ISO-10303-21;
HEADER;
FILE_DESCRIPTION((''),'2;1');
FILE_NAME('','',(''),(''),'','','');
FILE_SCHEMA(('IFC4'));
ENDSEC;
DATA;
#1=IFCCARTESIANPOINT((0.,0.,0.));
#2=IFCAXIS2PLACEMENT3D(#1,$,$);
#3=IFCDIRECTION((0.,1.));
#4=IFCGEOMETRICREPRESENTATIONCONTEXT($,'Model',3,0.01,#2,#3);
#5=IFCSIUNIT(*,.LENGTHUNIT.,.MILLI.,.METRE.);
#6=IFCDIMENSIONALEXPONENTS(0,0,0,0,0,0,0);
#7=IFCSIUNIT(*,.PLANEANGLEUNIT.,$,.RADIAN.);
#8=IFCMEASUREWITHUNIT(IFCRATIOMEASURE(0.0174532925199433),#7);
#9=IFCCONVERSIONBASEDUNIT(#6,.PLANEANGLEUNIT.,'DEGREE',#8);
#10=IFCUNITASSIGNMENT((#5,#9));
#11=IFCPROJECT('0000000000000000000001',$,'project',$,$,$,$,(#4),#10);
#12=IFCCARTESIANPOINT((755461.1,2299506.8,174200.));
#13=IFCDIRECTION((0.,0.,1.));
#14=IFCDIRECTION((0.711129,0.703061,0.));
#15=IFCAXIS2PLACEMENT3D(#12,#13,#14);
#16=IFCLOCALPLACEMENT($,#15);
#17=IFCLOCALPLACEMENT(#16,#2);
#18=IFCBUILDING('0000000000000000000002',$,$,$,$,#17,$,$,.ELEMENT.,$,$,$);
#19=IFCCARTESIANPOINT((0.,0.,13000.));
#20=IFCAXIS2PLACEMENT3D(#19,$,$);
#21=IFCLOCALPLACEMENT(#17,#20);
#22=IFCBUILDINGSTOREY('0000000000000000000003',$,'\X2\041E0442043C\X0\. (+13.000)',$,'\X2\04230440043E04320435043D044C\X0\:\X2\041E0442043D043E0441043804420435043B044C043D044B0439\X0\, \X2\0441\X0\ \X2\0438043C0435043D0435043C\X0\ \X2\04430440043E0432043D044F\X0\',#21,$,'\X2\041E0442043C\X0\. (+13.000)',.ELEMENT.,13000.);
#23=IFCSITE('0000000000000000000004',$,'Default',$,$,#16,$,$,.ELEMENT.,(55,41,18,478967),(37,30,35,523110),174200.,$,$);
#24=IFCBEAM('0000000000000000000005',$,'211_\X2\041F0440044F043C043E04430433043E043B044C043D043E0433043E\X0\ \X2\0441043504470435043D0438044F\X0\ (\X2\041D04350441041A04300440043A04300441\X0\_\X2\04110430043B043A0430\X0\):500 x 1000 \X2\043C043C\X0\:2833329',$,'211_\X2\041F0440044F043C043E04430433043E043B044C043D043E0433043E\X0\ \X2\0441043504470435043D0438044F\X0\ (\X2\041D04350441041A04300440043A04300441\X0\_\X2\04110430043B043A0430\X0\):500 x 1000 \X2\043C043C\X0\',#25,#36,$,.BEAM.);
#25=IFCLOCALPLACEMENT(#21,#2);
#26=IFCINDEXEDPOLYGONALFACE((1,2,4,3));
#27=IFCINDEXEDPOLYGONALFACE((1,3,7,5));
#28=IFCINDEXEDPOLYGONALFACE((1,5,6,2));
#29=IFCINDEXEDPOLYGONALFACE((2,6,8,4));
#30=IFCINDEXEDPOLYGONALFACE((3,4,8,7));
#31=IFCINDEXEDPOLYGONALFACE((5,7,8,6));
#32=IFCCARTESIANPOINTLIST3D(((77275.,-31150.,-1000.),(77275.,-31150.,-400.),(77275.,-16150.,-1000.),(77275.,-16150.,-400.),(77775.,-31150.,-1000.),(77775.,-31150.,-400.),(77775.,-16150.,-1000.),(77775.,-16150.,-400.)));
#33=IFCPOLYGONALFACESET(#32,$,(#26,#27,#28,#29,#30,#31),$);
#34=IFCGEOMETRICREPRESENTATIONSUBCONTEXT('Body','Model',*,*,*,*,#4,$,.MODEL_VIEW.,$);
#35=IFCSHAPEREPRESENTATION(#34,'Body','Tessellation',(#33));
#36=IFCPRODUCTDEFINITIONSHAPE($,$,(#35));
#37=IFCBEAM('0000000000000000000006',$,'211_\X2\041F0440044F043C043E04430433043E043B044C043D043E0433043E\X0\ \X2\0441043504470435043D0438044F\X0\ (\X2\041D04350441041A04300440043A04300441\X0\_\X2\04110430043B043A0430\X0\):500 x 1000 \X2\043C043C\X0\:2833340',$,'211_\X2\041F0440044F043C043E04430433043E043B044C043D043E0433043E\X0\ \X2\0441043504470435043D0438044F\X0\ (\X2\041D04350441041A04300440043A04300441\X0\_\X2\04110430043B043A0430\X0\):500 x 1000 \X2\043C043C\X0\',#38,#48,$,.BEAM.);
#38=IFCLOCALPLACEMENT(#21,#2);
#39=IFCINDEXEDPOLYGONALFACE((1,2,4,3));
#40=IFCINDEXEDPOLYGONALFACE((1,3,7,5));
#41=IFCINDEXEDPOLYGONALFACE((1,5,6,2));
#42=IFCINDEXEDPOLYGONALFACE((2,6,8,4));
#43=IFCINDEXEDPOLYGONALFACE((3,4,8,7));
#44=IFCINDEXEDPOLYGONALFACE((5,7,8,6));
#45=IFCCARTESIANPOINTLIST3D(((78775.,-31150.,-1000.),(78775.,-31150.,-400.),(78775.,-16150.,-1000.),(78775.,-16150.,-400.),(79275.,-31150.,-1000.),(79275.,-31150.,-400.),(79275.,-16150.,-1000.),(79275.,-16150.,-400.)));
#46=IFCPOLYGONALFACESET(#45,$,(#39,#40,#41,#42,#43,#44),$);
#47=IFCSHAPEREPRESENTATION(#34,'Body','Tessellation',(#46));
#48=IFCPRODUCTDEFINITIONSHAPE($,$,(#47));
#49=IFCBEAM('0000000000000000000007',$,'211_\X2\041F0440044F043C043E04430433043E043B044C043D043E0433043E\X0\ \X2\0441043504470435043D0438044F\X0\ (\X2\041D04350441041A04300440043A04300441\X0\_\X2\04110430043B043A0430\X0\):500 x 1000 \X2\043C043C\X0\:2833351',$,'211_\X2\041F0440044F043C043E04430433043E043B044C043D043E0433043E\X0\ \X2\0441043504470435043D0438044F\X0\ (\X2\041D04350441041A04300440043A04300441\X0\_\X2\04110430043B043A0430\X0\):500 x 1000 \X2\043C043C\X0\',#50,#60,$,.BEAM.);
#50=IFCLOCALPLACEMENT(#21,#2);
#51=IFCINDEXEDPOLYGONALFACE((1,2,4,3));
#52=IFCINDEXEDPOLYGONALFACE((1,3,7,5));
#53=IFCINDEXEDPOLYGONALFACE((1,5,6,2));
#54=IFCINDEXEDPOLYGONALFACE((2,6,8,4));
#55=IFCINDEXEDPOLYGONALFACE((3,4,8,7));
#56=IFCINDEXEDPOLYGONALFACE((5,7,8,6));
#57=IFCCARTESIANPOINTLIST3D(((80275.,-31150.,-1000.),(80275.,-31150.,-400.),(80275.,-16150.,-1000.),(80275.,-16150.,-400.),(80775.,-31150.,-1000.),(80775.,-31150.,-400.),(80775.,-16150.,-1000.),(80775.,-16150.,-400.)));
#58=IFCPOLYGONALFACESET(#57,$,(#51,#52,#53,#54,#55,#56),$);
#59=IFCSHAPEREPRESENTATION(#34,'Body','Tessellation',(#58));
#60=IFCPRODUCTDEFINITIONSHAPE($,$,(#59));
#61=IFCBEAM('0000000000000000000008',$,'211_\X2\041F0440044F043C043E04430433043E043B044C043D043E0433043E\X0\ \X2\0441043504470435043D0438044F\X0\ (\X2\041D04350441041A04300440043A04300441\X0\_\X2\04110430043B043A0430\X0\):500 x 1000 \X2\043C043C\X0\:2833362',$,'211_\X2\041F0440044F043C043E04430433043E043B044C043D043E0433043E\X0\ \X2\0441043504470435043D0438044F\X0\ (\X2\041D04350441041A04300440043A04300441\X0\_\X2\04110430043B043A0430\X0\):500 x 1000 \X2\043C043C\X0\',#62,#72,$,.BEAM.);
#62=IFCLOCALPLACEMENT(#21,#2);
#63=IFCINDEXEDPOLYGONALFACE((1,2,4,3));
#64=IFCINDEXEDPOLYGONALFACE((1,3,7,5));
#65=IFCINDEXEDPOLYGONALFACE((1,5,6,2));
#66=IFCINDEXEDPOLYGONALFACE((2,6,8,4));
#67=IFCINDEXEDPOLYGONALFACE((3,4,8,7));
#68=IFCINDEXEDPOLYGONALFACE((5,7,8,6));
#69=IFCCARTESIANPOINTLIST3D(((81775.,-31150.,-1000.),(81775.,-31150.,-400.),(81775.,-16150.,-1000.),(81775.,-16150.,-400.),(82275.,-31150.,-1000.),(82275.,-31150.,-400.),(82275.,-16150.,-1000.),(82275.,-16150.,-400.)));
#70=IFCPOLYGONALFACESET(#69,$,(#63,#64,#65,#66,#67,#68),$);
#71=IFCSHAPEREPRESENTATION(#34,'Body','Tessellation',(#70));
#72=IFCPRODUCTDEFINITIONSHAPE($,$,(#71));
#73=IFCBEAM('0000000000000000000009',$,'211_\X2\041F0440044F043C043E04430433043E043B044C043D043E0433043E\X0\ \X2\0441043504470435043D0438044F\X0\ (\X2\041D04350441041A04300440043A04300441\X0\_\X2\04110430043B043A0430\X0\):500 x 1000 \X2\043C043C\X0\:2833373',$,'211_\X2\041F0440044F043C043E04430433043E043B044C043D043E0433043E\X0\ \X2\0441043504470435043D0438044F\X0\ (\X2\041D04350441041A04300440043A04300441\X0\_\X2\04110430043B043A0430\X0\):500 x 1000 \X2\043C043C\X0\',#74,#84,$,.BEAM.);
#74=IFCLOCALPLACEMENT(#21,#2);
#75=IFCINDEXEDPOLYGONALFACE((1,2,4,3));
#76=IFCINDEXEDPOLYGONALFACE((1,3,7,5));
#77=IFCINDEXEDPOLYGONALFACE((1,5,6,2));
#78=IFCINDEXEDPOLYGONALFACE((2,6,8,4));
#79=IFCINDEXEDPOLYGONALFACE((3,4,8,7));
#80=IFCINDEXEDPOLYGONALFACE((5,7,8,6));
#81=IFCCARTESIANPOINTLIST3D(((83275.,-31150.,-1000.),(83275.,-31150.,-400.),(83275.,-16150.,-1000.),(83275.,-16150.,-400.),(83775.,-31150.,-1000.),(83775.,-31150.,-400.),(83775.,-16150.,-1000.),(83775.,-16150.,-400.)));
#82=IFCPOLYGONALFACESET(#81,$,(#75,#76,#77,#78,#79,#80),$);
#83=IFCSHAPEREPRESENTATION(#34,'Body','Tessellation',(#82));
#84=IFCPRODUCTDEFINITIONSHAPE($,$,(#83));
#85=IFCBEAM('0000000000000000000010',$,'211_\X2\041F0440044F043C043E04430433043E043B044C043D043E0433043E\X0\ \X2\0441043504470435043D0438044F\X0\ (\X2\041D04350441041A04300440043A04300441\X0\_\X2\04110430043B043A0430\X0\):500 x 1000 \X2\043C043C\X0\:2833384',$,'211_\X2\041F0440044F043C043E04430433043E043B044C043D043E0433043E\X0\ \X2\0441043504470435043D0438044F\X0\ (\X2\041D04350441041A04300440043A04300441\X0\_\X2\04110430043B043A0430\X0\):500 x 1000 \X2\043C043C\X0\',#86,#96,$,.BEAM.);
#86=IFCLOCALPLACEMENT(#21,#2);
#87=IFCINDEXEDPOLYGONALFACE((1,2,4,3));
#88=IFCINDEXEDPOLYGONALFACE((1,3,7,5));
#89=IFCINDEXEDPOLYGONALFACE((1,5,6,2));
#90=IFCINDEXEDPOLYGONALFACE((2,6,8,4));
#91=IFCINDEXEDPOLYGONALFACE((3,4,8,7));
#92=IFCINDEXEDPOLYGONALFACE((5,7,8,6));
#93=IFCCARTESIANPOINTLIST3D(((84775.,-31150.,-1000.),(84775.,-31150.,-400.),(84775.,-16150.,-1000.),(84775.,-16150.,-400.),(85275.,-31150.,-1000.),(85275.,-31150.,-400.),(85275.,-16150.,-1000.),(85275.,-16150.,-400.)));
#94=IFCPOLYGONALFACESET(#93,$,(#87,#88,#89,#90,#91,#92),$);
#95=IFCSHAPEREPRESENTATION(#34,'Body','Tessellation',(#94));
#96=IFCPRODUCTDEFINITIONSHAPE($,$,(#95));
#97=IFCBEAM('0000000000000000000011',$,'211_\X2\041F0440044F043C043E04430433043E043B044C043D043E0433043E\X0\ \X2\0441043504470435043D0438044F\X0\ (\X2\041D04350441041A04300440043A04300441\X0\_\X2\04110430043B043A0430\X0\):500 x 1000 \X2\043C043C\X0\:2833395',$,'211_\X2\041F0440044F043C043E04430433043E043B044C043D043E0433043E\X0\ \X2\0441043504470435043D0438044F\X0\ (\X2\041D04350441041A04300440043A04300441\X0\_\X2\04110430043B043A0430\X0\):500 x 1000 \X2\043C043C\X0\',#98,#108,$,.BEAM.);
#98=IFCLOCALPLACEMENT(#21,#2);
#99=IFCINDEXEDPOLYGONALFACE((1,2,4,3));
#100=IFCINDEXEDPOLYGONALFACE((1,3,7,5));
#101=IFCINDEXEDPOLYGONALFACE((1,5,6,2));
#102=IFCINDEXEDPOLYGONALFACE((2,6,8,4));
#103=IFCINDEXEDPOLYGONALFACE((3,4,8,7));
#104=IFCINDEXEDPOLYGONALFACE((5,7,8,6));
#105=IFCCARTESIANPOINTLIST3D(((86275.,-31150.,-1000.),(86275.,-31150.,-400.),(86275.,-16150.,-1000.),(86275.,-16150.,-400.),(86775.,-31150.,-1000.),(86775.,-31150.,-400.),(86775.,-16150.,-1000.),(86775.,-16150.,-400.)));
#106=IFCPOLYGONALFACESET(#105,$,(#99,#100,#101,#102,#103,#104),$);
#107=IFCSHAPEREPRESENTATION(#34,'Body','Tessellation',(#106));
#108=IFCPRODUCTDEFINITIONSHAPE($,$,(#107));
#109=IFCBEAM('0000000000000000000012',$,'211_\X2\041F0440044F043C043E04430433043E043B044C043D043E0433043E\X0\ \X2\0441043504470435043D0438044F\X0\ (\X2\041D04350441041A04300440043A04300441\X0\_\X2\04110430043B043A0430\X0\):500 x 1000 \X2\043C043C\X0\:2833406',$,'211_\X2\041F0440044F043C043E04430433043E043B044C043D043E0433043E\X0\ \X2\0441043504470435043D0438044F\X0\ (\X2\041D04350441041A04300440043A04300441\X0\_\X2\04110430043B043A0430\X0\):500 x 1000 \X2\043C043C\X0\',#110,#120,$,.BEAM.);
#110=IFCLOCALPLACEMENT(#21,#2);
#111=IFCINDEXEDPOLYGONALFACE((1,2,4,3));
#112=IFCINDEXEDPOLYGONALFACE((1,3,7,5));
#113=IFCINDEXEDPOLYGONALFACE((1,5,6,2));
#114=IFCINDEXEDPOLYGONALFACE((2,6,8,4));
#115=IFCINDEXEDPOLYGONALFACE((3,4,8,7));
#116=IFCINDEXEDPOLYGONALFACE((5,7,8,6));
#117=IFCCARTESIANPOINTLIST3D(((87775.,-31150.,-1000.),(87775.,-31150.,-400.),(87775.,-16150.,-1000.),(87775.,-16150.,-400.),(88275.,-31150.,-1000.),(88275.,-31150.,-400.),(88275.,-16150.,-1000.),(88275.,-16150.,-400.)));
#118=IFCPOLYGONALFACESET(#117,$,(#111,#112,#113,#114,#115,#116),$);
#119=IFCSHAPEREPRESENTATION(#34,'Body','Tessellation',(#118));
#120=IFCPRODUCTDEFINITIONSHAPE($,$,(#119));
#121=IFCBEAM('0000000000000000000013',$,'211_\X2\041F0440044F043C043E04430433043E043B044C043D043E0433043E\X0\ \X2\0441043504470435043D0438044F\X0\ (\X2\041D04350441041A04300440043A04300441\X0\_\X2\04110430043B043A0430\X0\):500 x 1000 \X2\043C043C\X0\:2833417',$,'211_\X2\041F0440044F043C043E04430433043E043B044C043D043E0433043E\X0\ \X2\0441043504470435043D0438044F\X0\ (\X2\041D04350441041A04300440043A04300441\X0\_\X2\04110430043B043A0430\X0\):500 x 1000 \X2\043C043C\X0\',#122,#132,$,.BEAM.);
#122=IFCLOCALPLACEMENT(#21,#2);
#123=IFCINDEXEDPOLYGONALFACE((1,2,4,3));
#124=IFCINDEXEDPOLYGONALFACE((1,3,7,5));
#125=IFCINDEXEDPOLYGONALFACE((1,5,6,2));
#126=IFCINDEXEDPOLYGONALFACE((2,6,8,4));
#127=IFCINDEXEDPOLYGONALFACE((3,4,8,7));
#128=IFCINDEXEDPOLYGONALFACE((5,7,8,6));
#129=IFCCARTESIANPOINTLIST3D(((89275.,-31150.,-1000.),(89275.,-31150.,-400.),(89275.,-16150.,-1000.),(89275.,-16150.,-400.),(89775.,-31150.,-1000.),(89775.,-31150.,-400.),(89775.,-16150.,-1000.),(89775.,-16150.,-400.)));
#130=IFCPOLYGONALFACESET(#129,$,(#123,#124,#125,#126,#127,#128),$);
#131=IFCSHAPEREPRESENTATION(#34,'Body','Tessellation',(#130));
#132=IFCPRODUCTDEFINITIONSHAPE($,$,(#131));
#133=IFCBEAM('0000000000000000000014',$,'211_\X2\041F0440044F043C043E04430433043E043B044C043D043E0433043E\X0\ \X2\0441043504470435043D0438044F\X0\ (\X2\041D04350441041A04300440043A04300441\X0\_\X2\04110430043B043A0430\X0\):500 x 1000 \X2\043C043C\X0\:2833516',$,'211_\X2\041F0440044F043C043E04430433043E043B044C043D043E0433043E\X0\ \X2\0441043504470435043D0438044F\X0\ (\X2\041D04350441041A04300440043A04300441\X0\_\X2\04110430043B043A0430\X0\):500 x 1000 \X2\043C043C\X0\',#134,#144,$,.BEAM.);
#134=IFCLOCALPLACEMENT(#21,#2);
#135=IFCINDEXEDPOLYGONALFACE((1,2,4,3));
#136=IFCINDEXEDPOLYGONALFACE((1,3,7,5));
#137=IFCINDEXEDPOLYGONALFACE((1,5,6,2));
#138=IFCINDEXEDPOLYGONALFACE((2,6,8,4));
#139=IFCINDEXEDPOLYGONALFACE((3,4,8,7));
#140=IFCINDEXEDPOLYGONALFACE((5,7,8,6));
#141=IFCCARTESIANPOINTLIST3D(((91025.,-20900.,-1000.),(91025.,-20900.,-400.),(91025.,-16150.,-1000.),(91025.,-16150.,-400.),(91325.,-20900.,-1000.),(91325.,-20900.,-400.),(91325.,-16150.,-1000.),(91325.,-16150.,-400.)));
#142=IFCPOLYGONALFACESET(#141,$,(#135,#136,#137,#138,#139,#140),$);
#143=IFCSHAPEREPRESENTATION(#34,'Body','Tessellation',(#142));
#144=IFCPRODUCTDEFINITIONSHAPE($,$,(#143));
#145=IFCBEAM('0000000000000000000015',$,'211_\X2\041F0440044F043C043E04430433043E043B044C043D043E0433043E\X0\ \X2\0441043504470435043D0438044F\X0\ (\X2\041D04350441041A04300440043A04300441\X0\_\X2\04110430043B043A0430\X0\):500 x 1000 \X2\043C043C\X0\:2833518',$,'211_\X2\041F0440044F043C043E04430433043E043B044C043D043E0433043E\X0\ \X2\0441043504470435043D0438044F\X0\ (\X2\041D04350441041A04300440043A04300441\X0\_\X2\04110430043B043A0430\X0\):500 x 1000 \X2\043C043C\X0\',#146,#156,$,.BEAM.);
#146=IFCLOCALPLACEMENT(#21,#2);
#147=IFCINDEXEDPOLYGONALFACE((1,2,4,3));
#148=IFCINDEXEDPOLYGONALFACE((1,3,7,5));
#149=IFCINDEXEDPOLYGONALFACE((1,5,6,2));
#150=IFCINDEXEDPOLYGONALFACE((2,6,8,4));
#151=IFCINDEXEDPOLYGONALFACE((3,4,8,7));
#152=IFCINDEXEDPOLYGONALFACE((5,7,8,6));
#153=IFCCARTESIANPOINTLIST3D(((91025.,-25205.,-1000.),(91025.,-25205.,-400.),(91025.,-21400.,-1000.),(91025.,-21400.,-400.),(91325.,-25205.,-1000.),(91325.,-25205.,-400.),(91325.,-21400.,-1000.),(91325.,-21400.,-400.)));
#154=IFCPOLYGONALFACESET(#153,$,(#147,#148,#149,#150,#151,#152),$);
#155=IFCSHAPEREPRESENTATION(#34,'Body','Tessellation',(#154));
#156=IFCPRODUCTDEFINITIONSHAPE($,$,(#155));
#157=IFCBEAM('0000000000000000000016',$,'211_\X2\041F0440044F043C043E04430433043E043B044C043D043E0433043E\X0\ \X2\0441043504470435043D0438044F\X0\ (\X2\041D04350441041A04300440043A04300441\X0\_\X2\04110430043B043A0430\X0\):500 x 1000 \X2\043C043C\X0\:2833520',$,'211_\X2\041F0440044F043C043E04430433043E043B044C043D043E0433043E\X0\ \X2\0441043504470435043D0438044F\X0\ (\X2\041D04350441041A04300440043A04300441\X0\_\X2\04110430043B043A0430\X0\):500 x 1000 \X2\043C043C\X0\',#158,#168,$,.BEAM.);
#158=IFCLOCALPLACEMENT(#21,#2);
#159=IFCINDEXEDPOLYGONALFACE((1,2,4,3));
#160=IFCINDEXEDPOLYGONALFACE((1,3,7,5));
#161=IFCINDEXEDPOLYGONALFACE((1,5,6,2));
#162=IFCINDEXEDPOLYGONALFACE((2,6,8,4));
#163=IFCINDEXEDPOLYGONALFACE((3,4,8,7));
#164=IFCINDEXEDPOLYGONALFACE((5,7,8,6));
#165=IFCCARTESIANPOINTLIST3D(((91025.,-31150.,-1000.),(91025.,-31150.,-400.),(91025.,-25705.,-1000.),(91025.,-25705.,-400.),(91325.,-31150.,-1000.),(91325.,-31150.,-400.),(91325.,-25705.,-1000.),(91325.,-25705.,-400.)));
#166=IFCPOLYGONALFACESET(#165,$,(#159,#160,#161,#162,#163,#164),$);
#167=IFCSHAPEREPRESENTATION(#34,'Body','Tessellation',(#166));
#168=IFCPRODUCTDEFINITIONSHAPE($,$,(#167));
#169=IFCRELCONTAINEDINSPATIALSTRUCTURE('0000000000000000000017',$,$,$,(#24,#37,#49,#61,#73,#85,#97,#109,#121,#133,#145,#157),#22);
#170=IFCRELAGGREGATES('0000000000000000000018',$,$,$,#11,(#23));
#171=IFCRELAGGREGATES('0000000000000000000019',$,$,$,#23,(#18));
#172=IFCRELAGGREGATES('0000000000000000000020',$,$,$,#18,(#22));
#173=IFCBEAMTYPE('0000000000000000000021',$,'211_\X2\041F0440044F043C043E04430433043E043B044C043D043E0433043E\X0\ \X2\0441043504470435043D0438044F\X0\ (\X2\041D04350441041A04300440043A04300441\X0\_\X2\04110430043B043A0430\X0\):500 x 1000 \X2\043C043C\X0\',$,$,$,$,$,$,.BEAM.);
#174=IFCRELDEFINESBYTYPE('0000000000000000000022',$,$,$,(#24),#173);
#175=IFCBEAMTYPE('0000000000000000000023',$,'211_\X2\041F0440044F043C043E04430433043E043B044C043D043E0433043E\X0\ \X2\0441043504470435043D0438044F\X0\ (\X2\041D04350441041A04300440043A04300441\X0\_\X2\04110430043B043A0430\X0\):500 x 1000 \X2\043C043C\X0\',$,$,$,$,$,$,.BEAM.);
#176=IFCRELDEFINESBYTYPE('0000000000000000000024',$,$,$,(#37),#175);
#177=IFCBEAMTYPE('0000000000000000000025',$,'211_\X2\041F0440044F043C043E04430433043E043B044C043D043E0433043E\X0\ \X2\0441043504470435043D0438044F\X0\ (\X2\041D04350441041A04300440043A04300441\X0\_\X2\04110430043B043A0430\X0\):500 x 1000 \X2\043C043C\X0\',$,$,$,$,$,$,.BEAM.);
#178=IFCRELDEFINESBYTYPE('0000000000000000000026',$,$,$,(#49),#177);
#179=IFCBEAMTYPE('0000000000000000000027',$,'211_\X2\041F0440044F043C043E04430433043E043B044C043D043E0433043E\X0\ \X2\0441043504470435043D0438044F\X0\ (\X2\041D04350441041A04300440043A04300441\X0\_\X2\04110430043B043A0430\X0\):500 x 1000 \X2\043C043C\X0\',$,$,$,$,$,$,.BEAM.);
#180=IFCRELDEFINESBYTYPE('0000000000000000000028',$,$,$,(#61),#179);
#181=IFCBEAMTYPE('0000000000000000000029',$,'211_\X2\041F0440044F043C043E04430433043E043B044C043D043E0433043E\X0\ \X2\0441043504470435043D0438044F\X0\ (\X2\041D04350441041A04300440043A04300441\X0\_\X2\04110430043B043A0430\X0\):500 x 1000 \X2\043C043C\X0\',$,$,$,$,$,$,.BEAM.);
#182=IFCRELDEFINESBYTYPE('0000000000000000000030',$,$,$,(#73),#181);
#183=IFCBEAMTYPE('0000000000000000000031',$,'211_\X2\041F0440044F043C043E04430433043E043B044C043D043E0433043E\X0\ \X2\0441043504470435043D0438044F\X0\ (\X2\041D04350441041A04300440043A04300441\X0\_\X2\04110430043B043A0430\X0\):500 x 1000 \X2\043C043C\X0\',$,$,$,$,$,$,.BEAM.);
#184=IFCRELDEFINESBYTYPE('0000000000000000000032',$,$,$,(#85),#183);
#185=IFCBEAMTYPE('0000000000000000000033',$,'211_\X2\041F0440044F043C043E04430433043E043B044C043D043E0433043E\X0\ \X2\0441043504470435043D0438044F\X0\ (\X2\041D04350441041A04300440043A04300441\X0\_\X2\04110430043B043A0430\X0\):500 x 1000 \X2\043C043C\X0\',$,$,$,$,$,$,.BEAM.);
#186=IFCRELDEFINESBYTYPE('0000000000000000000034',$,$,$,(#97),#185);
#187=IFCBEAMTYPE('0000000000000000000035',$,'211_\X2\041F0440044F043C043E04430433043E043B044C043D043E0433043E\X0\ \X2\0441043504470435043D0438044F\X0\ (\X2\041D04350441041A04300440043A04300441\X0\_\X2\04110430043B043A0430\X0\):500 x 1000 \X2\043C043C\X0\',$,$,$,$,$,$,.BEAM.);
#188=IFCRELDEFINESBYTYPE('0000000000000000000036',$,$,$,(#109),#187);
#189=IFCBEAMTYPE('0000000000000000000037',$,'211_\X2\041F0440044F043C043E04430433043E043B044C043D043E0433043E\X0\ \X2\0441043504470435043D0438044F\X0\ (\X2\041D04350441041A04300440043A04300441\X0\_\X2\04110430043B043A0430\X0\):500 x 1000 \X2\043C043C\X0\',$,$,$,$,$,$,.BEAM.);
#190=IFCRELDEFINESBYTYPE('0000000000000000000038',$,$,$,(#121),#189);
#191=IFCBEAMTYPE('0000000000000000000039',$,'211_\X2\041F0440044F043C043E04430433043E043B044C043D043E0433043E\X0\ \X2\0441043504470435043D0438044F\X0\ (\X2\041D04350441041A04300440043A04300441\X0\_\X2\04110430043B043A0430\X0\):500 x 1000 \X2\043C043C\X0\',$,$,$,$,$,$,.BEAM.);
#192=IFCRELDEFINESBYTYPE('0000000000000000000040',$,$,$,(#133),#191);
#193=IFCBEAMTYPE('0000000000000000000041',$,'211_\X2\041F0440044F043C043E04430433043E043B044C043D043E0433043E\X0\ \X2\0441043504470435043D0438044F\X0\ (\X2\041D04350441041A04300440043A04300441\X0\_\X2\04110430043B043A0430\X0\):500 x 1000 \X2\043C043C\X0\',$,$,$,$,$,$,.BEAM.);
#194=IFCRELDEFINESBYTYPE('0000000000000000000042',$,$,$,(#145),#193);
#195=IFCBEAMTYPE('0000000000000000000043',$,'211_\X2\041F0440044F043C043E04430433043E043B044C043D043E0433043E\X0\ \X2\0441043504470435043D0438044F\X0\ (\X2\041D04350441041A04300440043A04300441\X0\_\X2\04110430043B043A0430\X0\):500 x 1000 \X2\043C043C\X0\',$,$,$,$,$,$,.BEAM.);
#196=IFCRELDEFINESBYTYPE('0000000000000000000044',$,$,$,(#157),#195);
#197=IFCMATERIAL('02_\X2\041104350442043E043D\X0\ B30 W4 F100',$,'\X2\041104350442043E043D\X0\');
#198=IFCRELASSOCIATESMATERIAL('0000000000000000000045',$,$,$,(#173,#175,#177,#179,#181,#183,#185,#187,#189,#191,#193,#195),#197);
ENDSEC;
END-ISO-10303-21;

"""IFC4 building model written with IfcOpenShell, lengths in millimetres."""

from ifc_helpers import new_model, entity, si_unit, converted_unit, direction, frame, origin, place, context, subcontext, project, spatial, indexed_curve, outline, extrude, source, transform, mapped, material, type_object, type_shapes, element, save


model = new_model("IFC4")

# Units and contexts
model_context = context("Model", 3, precision=0.01, world=origin(), true_north=direction((0.0, 1.0)))
body_context = subcontext(model_context, "Body", "Model", "MODEL_VIEW")
ifc_project = project(units=[si_unit("LENGTHUNIT", "METRE", prefix="MILLI"), converted_unit("PLANEANGLEUNIT", "DEGREE", entity("IfcRatioMeasure", 0.0174532925199433), si_unit("PLANEANGLEUNIT", "RADIAN"), dimensions=[0, 0, 0, 0, 0, 0, 0])], contexts=[model_context])

# Site, building, storey
site_placement = place(None, frame((755461.1, 2299506.8, 174200.0), z_axis=(0.0, 0.0, 1.0), x_axis=(0.711129, 0.703061, 0.0)))
site = spatial("IfcSite", under=ifc_project, at=site_placement, Name="Default", CompositionType="ELEMENT", RefLatitude=(55, 41, 18, 478967), RefLongitude=(37, 30, 35, 523110), RefElevation=174200.0)
building_placement = place(site_placement, origin())
building = spatial("IfcBuilding", under=site, at=building_placement, CompositionType="ELEMENT")
storey_placement = place(building_placement, frame((0.0, 0.0, 13000.0)))
storey = spatial("IfcBuildingStorey", under=building, at=storey_placement, Name="Отм. (+13.000)", ObjectType="Уровень:Относительный, с именем уровня", LongName="Отм. (+13.000)", CompositionType="ELEMENT", Elevation=13000.0)

# Beams
ifc_material_1 = material(Name="02_Бетон B30 W4 F100", Category="Бетон")
beam_type_1 = type_object("IfcBeamType", Name="211_Прямоугольного сечения (НесКаркас_Балка):500 x 1000 мм", PredefinedType="BEAM", material=ifc_material_1)
shared_shape_1 = source(origin(), body_context, "Body", "SweptSolid", [
    extrude(outline(indexed_curve([(-250.0, -300.0), (250.0, -300.0), (250.0, 300.0), (-250.0, 300.0), (-250.0, -300.0)], self_intersect=False)), frame((77525.0, -16150.0, 12300.0), z_axis=(0.0, -1.0, 0.0), x_axis=(-1.0, 0.0, 0.0)), (0.0, 0.0, 1.0), 15000.0),
])
type_shapes(beam_type_1, [shared_shape_1])
beam_1_placement = place(storey_placement, frame((0.0, 0.0, -13000.0)))
element("IfcBeam", 1, at=beam_1_placement, inside=storey, type_object=beam_type_1, Name="211_Прямоугольного сечения (НесКаркас_Балка):500 x 1000 мм:2833329", ObjectType="211_Прямоугольного сечения (НесКаркас_Балка):500 x 1000 мм", PredefinedType="BEAM", context=body_context, shape_type="MappedRepresentation", body=[
    mapped(shared_shape_1, transform((0.0, 0.0, 0.0), scale=1.0)),
])
beam_type_2 = type_object("IfcBeamType", Name="211_Прямоугольного сечения (НесКаркас_Балка):500 x 1000 мм", PredefinedType="BEAM", material=ifc_material_1)
shared_shape_2 = source(origin(), body_context, "Body", "SweptSolid", [
    extrude(outline(indexed_curve([(-250.0, -300.0), (250.0, -300.0), (250.0, 300.0), (-250.0, 300.0), (-250.0, -300.0)], self_intersect=False)), frame((79025.0, -16150.0, 12300.0), z_axis=(0.0, -1.0, 0.0), x_axis=(-1.0, 0.0, 0.0)), (0.0, 0.0, 1.0), 15000.0),
])
type_shapes(beam_type_2, [shared_shape_2])
beam_2_placement = place(storey_placement, frame((0.0, 0.0, -13000.0)))
element("IfcBeam", 2, at=beam_2_placement, inside=storey, type_object=beam_type_2, Name="211_Прямоугольного сечения (НесКаркас_Балка):500 x 1000 мм:2833340", ObjectType="211_Прямоугольного сечения (НесКаркас_Балка):500 x 1000 мм", PredefinedType="BEAM", context=body_context, shape_type="MappedRepresentation", body=[
    mapped(shared_shape_2, transform((0.0, 0.0, 0.0), scale=1.0)),
])
beam_type_3 = type_object("IfcBeamType", Name="211_Прямоугольного сечения (НесКаркас_Балка):500 x 1000 мм", PredefinedType="BEAM", material=ifc_material_1)
shared_shape_3 = source(origin(), body_context, "Body", "SweptSolid", [
    extrude(outline(indexed_curve([(-250.0, -300.0), (250.0, -300.0), (250.0, 300.0), (-250.0, 300.0), (-250.0, -300.0)], self_intersect=False)), frame((80525.0, -16150.0, 12300.0), z_axis=(0.0, -1.0, 0.0), x_axis=(-1.0, 0.0, 0.0)), (0.0, 0.0, 1.0), 15000.0),
])
type_shapes(beam_type_3, [shared_shape_3])
beam_3_placement = place(storey_placement, frame((0.0, 0.0, -13000.0)))
element("IfcBeam", 3, at=beam_3_placement, inside=storey, type_object=beam_type_3, Name="211_Прямоугольного сечения (НесКаркас_Балка):500 x 1000 мм:2833351", ObjectType="211_Прямоугольного сечения (НесКаркас_Балка):500 x 1000 мм", PredefinedType="BEAM", context=body_context, shape_type="MappedRepresentation", body=[
    mapped(shared_shape_3, transform((0.0, 0.0, 0.0), scale=1.0)),
])
beam_type_4 = type_object("IfcBeamType", Name="211_Прямоугольного сечения (НесКаркас_Балка):500 x 1000 мм", PredefinedType="BEAM", material=ifc_material_1)
shared_shape_4 = source(origin(), body_context, "Body", "SweptSolid", [
    extrude(outline(indexed_curve([(-250.0, -300.0), (250.0, -300.0), (250.0, 300.0), (-250.0, 300.0), (-250.0, -300.0)], self_intersect=False)), frame((82025.0, -16150.0, 12300.0), z_axis=(0.0, -1.0, 0.0), x_axis=(-1.0, 0.0, 0.0)), (0.0, 0.0, 1.0), 15000.0),
])
type_shapes(beam_type_4, [shared_shape_4])
beam_4_placement = place(storey_placement, frame((0.0, 0.0, -13000.0)))
element("IfcBeam", 4, at=beam_4_placement, inside=storey, type_object=beam_type_4, Name="211_Прямоугольного сечения (НесКаркас_Балка):500 x 1000 мм:2833362", ObjectType="211_Прямоугольного сечения (НесКаркас_Балка):500 x 1000 мм", PredefinedType="BEAM", context=body_context, shape_type="MappedRepresentation", body=[
    mapped(shared_shape_4, transform((0.0, 0.0, 0.0), scale=1.0)),
])
beam_type_5 = type_object("IfcBeamType", Name="211_Прямоугольного сечения (НесКаркас_Балка):500 x 1000 мм", PredefinedType="BEAM", material=ifc_material_1)
shared_shape_5 = source(origin(), body_context, "Body", "SweptSolid", [
    extrude(outline(indexed_curve([(-250.0, -300.0), (250.0, -300.0), (250.0, 300.0), (-250.0, 300.0), (-250.0, -300.0)], self_intersect=False)), frame((83525.0, -16150.0, 12300.0), z_axis=(0.0, -1.0, 0.0), x_axis=(-1.0, 0.0, 0.0)), (0.0, 0.0, 1.0), 15000.0),
])
type_shapes(beam_type_5, [shared_shape_5])
beam_5_placement = place(storey_placement, frame((0.0, 0.0, -13000.0)))
element("IfcBeam", 5, at=beam_5_placement, inside=storey, type_object=beam_type_5, Name="211_Прямоугольного сечения (НесКаркас_Балка):500 x 1000 мм:2833373", ObjectType="211_Прямоугольного сечения (НесКаркас_Балка):500 x 1000 мм", PredefinedType="BEAM", context=body_context, shape_type="MappedRepresentation", body=[
    mapped(shared_shape_5, transform((0.0, 0.0, 0.0), scale=1.0)),
])
beam_type_6 = type_object("IfcBeamType", Name="211_Прямоугольного сечения (НесКаркас_Балка):500 x 1000 мм", PredefinedType="BEAM", material=ifc_material_1)
shared_shape_6 = source(origin(), body_context, "Body", "SweptSolid", [
    extrude(outline(indexed_curve([(-250.0, -300.0), (250.0, -300.0), (250.0, 300.0), (-250.0, 300.0), (-250.0, -300.0)], self_intersect=False)), frame((85025.0, -16150.0, 12300.0), z_axis=(0.0, -1.0, 0.0), x_axis=(-1.0, 0.0, 0.0)), (0.0, 0.0, 1.0), 15000.0),
])
type_shapes(beam_type_6, [shared_shape_6])
beam_6_placement = place(storey_placement, frame((0.0, 0.0, -13000.0)))
element("IfcBeam", 6, at=beam_6_placement, inside=storey, type_object=beam_type_6, Name="211_Прямоугольного сечения (НесКаркас_Балка):500 x 1000 мм:2833384", ObjectType="211_Прямоугольного сечения (НесКаркас_Балка):500 x 1000 мм", PredefinedType="BEAM", context=body_context, shape_type="MappedRepresentation", body=[
    mapped(shared_shape_6, transform((0.0, 0.0, 0.0), scale=1.0)),
])
beam_type_7 = type_object("IfcBeamType", Name="211_Прямоугольного сечения (НесКаркас_Балка):500 x 1000 мм", PredefinedType="BEAM", material=ifc_material_1)
shared_shape_7 = source(origin(), body_context, "Body", "SweptSolid", [
    extrude(outline(indexed_curve([(-250.0, -300.0), (250.0, -300.0), (250.0, 300.0), (-250.0, 300.0), (-250.0, -300.0)], self_intersect=False)), frame((86525.0, -16150.0, 12300.0), z_axis=(0.0, -1.0, 0.0), x_axis=(-1.0, 0.0, 0.0)), (0.0, 0.0, 1.0), 15000.0),
])
type_shapes(beam_type_7, [shared_shape_7])
beam_7_placement = place(storey_placement, frame((0.0, 0.0, -13000.0)))
element("IfcBeam", 7, at=beam_7_placement, inside=storey, type_object=beam_type_7, Name="211_Прямоугольного сечения (НесКаркас_Балка):500 x 1000 мм:2833395", ObjectType="211_Прямоугольного сечения (НесКаркас_Балка):500 x 1000 мм", PredefinedType="BEAM", context=body_context, shape_type="MappedRepresentation", body=[
    mapped(shared_shape_7, transform((0.0, 0.0, 0.0), scale=1.0)),
])
beam_type_8 = type_object("IfcBeamType", Name="211_Прямоугольного сечения (НесКаркас_Балка):500 x 1000 мм", PredefinedType="BEAM", material=ifc_material_1)
shared_shape_8 = source(origin(), body_context, "Body", "SweptSolid", [
    extrude(outline(indexed_curve([(-250.0, -300.0), (250.0, -300.0), (250.0, 300.0), (-250.0, 300.0), (-250.0, -300.0)], self_intersect=False)), frame((88025.0, -16150.0, 12300.0), z_axis=(0.0, -1.0, 0.0), x_axis=(-1.0, 0.0, 0.0)), (0.0, 0.0, 1.0), 15000.0),
])
type_shapes(beam_type_8, [shared_shape_8])
beam_8_placement = place(storey_placement, frame((0.0, 0.0, -13000.0)))
element("IfcBeam", 8, at=beam_8_placement, inside=storey, type_object=beam_type_8, Name="211_Прямоугольного сечения (НесКаркас_Балка):500 x 1000 мм:2833406", ObjectType="211_Прямоугольного сечения (НесКаркас_Балка):500 x 1000 мм", PredefinedType="BEAM", context=body_context, shape_type="MappedRepresentation", body=[
    mapped(shared_shape_8, transform((0.0, 0.0, 0.0), scale=1.0)),
])
beam_type_9 = type_object("IfcBeamType", Name="211_Прямоугольного сечения (НесКаркас_Балка):500 x 1000 мм", PredefinedType="BEAM", material=ifc_material_1)
shared_shape_9 = source(origin(), body_context, "Body", "SweptSolid", [
    extrude(outline(indexed_curve([(-250.0, -300.0), (250.0, -300.0), (250.0, 300.0), (-250.0, 300.0), (-250.0, -300.0)], self_intersect=False)), frame((89525.0, -16150.0, 12300.0), z_axis=(0.0, -1.0, 0.0), x_axis=(-1.0, 0.0, 0.0)), (0.0, 0.0, 1.0), 15000.0),
])
type_shapes(beam_type_9, [shared_shape_9])
beam_9_placement = place(storey_placement, frame((0.0, 0.0, -13000.0)))
element("IfcBeam", 9, at=beam_9_placement, inside=storey, type_object=beam_type_9, Name="211_Прямоугольного сечения (НесКаркас_Балка):500 x 1000 мм:2833417", ObjectType="211_Прямоугольного сечения (НесКаркас_Балка):500 x 1000 мм", PredefinedType="BEAM", context=body_context, shape_type="MappedRepresentation", body=[
    mapped(shared_shape_9, transform((0.0, 0.0, 0.0), scale=1.0)),
])
beam_type_10 = type_object("IfcBeamType", Name="211_Прямоугольного сечения (НесКаркас_Балка):500 x 1000 мм", PredefinedType="BEAM", material=ifc_material_1)
shared_shape_10 = source(origin(), body_context, "Body", "SweptSolid", [
    extrude(outline(indexed_curve([(-150.0, -300.0), (150.0, -300.0), (150.0, 300.0), (-150.0, 300.0), (-150.0, -300.0)], self_intersect=False)), frame((91175.0, -16150.0, 12300.0), z_axis=(0.0, -1.0, 0.0), x_axis=(-1.0, 0.0, 0.0)), (0.0, 0.0, 1.0), 4750.0),
])
type_shapes(beam_type_10, [shared_shape_10])
beam_10_placement = place(storey_placement, frame((0.0, 0.0, -13000.0)))
element("IfcBeam", 10, at=beam_10_placement, inside=storey, type_object=beam_type_10, Name="211_Прямоугольного сечения (НесКаркас_Балка):500 x 1000 мм:2833516", ObjectType="211_Прямоугольного сечения (НесКаркас_Балка):500 x 1000 мм", PredefinedType="BEAM", context=body_context, shape_type="MappedRepresentation", body=[
    mapped(shared_shape_10, transform((0.0, 0.0, 0.0), scale=1.0)),
])
beam_type_11 = type_object("IfcBeamType", Name="211_Прямоугольного сечения (НесКаркас_Балка):500 x 1000 мм", PredefinedType="BEAM", material=ifc_material_1)
shared_shape_11 = source(origin(), body_context, "Body", "SweptSolid", [
    extrude(outline(indexed_curve([(-150.0, -300.0), (150.0, -300.0), (150.0, 300.0), (-150.0, 300.0), (-150.0, -300.0)], self_intersect=False)), frame((91175.0, -21400.0, 12300.0), z_axis=(0.0, -1.0, 0.0), x_axis=(-1.0, 0.0, 0.0)), (0.0, 0.0, 1.0), 3805.0),
])
type_shapes(beam_type_11, [shared_shape_11])
beam_11_placement = place(storey_placement, frame((0.0, 0.0, -13000.0)))
element("IfcBeam", 11, at=beam_11_placement, inside=storey, type_object=beam_type_11, Name="211_Прямоугольного сечения (НесКаркас_Балка):500 x 1000 мм:2833518", ObjectType="211_Прямоугольного сечения (НесКаркас_Балка):500 x 1000 мм", PredefinedType="BEAM", context=body_context, shape_type="MappedRepresentation", body=[
    mapped(shared_shape_11, transform((0.0, 0.0, 0.0), scale=1.0)),
])
beam_type_12 = type_object("IfcBeamType", Name="211_Прямоугольного сечения (НесКаркас_Балка):500 x 1000 мм", PredefinedType="BEAM", material=ifc_material_1)
shared_shape_12 = source(origin(), body_context, "Body", "SweptSolid", [
    extrude(outline(indexed_curve([(-150.0, -300.0), (150.0, -300.0), (150.0, 300.0), (-150.0, 300.0), (-150.0, -300.0)], self_intersect=False)), frame((91175.0, -25705.0, 12300.0), z_axis=(0.0, -1.0, 0.0), x_axis=(-1.0, 0.0, 0.0)), (0.0, 0.0, 1.0), 5445.0),
])
type_shapes(beam_type_12, [shared_shape_12])
beam_12_placement = place(storey_placement, frame((0.0, 0.0, -13000.0)))
element("IfcBeam", 12, at=beam_12_placement, inside=storey, type_object=beam_type_12, Name="211_Прямоугольного сечения (НесКаркас_Балка):500 x 1000 мм:2833520", ObjectType="211_Прямоугольного сечения (НесКаркас_Балка):500 x 1000 мм", PredefinedType="BEAM", context=body_context, shape_type="MappedRepresentation", body=[
    mapped(shared_shape_12, transform((0.0, 0.0, 0.0), scale=1.0)),
])

save(model, "model.ifc")
